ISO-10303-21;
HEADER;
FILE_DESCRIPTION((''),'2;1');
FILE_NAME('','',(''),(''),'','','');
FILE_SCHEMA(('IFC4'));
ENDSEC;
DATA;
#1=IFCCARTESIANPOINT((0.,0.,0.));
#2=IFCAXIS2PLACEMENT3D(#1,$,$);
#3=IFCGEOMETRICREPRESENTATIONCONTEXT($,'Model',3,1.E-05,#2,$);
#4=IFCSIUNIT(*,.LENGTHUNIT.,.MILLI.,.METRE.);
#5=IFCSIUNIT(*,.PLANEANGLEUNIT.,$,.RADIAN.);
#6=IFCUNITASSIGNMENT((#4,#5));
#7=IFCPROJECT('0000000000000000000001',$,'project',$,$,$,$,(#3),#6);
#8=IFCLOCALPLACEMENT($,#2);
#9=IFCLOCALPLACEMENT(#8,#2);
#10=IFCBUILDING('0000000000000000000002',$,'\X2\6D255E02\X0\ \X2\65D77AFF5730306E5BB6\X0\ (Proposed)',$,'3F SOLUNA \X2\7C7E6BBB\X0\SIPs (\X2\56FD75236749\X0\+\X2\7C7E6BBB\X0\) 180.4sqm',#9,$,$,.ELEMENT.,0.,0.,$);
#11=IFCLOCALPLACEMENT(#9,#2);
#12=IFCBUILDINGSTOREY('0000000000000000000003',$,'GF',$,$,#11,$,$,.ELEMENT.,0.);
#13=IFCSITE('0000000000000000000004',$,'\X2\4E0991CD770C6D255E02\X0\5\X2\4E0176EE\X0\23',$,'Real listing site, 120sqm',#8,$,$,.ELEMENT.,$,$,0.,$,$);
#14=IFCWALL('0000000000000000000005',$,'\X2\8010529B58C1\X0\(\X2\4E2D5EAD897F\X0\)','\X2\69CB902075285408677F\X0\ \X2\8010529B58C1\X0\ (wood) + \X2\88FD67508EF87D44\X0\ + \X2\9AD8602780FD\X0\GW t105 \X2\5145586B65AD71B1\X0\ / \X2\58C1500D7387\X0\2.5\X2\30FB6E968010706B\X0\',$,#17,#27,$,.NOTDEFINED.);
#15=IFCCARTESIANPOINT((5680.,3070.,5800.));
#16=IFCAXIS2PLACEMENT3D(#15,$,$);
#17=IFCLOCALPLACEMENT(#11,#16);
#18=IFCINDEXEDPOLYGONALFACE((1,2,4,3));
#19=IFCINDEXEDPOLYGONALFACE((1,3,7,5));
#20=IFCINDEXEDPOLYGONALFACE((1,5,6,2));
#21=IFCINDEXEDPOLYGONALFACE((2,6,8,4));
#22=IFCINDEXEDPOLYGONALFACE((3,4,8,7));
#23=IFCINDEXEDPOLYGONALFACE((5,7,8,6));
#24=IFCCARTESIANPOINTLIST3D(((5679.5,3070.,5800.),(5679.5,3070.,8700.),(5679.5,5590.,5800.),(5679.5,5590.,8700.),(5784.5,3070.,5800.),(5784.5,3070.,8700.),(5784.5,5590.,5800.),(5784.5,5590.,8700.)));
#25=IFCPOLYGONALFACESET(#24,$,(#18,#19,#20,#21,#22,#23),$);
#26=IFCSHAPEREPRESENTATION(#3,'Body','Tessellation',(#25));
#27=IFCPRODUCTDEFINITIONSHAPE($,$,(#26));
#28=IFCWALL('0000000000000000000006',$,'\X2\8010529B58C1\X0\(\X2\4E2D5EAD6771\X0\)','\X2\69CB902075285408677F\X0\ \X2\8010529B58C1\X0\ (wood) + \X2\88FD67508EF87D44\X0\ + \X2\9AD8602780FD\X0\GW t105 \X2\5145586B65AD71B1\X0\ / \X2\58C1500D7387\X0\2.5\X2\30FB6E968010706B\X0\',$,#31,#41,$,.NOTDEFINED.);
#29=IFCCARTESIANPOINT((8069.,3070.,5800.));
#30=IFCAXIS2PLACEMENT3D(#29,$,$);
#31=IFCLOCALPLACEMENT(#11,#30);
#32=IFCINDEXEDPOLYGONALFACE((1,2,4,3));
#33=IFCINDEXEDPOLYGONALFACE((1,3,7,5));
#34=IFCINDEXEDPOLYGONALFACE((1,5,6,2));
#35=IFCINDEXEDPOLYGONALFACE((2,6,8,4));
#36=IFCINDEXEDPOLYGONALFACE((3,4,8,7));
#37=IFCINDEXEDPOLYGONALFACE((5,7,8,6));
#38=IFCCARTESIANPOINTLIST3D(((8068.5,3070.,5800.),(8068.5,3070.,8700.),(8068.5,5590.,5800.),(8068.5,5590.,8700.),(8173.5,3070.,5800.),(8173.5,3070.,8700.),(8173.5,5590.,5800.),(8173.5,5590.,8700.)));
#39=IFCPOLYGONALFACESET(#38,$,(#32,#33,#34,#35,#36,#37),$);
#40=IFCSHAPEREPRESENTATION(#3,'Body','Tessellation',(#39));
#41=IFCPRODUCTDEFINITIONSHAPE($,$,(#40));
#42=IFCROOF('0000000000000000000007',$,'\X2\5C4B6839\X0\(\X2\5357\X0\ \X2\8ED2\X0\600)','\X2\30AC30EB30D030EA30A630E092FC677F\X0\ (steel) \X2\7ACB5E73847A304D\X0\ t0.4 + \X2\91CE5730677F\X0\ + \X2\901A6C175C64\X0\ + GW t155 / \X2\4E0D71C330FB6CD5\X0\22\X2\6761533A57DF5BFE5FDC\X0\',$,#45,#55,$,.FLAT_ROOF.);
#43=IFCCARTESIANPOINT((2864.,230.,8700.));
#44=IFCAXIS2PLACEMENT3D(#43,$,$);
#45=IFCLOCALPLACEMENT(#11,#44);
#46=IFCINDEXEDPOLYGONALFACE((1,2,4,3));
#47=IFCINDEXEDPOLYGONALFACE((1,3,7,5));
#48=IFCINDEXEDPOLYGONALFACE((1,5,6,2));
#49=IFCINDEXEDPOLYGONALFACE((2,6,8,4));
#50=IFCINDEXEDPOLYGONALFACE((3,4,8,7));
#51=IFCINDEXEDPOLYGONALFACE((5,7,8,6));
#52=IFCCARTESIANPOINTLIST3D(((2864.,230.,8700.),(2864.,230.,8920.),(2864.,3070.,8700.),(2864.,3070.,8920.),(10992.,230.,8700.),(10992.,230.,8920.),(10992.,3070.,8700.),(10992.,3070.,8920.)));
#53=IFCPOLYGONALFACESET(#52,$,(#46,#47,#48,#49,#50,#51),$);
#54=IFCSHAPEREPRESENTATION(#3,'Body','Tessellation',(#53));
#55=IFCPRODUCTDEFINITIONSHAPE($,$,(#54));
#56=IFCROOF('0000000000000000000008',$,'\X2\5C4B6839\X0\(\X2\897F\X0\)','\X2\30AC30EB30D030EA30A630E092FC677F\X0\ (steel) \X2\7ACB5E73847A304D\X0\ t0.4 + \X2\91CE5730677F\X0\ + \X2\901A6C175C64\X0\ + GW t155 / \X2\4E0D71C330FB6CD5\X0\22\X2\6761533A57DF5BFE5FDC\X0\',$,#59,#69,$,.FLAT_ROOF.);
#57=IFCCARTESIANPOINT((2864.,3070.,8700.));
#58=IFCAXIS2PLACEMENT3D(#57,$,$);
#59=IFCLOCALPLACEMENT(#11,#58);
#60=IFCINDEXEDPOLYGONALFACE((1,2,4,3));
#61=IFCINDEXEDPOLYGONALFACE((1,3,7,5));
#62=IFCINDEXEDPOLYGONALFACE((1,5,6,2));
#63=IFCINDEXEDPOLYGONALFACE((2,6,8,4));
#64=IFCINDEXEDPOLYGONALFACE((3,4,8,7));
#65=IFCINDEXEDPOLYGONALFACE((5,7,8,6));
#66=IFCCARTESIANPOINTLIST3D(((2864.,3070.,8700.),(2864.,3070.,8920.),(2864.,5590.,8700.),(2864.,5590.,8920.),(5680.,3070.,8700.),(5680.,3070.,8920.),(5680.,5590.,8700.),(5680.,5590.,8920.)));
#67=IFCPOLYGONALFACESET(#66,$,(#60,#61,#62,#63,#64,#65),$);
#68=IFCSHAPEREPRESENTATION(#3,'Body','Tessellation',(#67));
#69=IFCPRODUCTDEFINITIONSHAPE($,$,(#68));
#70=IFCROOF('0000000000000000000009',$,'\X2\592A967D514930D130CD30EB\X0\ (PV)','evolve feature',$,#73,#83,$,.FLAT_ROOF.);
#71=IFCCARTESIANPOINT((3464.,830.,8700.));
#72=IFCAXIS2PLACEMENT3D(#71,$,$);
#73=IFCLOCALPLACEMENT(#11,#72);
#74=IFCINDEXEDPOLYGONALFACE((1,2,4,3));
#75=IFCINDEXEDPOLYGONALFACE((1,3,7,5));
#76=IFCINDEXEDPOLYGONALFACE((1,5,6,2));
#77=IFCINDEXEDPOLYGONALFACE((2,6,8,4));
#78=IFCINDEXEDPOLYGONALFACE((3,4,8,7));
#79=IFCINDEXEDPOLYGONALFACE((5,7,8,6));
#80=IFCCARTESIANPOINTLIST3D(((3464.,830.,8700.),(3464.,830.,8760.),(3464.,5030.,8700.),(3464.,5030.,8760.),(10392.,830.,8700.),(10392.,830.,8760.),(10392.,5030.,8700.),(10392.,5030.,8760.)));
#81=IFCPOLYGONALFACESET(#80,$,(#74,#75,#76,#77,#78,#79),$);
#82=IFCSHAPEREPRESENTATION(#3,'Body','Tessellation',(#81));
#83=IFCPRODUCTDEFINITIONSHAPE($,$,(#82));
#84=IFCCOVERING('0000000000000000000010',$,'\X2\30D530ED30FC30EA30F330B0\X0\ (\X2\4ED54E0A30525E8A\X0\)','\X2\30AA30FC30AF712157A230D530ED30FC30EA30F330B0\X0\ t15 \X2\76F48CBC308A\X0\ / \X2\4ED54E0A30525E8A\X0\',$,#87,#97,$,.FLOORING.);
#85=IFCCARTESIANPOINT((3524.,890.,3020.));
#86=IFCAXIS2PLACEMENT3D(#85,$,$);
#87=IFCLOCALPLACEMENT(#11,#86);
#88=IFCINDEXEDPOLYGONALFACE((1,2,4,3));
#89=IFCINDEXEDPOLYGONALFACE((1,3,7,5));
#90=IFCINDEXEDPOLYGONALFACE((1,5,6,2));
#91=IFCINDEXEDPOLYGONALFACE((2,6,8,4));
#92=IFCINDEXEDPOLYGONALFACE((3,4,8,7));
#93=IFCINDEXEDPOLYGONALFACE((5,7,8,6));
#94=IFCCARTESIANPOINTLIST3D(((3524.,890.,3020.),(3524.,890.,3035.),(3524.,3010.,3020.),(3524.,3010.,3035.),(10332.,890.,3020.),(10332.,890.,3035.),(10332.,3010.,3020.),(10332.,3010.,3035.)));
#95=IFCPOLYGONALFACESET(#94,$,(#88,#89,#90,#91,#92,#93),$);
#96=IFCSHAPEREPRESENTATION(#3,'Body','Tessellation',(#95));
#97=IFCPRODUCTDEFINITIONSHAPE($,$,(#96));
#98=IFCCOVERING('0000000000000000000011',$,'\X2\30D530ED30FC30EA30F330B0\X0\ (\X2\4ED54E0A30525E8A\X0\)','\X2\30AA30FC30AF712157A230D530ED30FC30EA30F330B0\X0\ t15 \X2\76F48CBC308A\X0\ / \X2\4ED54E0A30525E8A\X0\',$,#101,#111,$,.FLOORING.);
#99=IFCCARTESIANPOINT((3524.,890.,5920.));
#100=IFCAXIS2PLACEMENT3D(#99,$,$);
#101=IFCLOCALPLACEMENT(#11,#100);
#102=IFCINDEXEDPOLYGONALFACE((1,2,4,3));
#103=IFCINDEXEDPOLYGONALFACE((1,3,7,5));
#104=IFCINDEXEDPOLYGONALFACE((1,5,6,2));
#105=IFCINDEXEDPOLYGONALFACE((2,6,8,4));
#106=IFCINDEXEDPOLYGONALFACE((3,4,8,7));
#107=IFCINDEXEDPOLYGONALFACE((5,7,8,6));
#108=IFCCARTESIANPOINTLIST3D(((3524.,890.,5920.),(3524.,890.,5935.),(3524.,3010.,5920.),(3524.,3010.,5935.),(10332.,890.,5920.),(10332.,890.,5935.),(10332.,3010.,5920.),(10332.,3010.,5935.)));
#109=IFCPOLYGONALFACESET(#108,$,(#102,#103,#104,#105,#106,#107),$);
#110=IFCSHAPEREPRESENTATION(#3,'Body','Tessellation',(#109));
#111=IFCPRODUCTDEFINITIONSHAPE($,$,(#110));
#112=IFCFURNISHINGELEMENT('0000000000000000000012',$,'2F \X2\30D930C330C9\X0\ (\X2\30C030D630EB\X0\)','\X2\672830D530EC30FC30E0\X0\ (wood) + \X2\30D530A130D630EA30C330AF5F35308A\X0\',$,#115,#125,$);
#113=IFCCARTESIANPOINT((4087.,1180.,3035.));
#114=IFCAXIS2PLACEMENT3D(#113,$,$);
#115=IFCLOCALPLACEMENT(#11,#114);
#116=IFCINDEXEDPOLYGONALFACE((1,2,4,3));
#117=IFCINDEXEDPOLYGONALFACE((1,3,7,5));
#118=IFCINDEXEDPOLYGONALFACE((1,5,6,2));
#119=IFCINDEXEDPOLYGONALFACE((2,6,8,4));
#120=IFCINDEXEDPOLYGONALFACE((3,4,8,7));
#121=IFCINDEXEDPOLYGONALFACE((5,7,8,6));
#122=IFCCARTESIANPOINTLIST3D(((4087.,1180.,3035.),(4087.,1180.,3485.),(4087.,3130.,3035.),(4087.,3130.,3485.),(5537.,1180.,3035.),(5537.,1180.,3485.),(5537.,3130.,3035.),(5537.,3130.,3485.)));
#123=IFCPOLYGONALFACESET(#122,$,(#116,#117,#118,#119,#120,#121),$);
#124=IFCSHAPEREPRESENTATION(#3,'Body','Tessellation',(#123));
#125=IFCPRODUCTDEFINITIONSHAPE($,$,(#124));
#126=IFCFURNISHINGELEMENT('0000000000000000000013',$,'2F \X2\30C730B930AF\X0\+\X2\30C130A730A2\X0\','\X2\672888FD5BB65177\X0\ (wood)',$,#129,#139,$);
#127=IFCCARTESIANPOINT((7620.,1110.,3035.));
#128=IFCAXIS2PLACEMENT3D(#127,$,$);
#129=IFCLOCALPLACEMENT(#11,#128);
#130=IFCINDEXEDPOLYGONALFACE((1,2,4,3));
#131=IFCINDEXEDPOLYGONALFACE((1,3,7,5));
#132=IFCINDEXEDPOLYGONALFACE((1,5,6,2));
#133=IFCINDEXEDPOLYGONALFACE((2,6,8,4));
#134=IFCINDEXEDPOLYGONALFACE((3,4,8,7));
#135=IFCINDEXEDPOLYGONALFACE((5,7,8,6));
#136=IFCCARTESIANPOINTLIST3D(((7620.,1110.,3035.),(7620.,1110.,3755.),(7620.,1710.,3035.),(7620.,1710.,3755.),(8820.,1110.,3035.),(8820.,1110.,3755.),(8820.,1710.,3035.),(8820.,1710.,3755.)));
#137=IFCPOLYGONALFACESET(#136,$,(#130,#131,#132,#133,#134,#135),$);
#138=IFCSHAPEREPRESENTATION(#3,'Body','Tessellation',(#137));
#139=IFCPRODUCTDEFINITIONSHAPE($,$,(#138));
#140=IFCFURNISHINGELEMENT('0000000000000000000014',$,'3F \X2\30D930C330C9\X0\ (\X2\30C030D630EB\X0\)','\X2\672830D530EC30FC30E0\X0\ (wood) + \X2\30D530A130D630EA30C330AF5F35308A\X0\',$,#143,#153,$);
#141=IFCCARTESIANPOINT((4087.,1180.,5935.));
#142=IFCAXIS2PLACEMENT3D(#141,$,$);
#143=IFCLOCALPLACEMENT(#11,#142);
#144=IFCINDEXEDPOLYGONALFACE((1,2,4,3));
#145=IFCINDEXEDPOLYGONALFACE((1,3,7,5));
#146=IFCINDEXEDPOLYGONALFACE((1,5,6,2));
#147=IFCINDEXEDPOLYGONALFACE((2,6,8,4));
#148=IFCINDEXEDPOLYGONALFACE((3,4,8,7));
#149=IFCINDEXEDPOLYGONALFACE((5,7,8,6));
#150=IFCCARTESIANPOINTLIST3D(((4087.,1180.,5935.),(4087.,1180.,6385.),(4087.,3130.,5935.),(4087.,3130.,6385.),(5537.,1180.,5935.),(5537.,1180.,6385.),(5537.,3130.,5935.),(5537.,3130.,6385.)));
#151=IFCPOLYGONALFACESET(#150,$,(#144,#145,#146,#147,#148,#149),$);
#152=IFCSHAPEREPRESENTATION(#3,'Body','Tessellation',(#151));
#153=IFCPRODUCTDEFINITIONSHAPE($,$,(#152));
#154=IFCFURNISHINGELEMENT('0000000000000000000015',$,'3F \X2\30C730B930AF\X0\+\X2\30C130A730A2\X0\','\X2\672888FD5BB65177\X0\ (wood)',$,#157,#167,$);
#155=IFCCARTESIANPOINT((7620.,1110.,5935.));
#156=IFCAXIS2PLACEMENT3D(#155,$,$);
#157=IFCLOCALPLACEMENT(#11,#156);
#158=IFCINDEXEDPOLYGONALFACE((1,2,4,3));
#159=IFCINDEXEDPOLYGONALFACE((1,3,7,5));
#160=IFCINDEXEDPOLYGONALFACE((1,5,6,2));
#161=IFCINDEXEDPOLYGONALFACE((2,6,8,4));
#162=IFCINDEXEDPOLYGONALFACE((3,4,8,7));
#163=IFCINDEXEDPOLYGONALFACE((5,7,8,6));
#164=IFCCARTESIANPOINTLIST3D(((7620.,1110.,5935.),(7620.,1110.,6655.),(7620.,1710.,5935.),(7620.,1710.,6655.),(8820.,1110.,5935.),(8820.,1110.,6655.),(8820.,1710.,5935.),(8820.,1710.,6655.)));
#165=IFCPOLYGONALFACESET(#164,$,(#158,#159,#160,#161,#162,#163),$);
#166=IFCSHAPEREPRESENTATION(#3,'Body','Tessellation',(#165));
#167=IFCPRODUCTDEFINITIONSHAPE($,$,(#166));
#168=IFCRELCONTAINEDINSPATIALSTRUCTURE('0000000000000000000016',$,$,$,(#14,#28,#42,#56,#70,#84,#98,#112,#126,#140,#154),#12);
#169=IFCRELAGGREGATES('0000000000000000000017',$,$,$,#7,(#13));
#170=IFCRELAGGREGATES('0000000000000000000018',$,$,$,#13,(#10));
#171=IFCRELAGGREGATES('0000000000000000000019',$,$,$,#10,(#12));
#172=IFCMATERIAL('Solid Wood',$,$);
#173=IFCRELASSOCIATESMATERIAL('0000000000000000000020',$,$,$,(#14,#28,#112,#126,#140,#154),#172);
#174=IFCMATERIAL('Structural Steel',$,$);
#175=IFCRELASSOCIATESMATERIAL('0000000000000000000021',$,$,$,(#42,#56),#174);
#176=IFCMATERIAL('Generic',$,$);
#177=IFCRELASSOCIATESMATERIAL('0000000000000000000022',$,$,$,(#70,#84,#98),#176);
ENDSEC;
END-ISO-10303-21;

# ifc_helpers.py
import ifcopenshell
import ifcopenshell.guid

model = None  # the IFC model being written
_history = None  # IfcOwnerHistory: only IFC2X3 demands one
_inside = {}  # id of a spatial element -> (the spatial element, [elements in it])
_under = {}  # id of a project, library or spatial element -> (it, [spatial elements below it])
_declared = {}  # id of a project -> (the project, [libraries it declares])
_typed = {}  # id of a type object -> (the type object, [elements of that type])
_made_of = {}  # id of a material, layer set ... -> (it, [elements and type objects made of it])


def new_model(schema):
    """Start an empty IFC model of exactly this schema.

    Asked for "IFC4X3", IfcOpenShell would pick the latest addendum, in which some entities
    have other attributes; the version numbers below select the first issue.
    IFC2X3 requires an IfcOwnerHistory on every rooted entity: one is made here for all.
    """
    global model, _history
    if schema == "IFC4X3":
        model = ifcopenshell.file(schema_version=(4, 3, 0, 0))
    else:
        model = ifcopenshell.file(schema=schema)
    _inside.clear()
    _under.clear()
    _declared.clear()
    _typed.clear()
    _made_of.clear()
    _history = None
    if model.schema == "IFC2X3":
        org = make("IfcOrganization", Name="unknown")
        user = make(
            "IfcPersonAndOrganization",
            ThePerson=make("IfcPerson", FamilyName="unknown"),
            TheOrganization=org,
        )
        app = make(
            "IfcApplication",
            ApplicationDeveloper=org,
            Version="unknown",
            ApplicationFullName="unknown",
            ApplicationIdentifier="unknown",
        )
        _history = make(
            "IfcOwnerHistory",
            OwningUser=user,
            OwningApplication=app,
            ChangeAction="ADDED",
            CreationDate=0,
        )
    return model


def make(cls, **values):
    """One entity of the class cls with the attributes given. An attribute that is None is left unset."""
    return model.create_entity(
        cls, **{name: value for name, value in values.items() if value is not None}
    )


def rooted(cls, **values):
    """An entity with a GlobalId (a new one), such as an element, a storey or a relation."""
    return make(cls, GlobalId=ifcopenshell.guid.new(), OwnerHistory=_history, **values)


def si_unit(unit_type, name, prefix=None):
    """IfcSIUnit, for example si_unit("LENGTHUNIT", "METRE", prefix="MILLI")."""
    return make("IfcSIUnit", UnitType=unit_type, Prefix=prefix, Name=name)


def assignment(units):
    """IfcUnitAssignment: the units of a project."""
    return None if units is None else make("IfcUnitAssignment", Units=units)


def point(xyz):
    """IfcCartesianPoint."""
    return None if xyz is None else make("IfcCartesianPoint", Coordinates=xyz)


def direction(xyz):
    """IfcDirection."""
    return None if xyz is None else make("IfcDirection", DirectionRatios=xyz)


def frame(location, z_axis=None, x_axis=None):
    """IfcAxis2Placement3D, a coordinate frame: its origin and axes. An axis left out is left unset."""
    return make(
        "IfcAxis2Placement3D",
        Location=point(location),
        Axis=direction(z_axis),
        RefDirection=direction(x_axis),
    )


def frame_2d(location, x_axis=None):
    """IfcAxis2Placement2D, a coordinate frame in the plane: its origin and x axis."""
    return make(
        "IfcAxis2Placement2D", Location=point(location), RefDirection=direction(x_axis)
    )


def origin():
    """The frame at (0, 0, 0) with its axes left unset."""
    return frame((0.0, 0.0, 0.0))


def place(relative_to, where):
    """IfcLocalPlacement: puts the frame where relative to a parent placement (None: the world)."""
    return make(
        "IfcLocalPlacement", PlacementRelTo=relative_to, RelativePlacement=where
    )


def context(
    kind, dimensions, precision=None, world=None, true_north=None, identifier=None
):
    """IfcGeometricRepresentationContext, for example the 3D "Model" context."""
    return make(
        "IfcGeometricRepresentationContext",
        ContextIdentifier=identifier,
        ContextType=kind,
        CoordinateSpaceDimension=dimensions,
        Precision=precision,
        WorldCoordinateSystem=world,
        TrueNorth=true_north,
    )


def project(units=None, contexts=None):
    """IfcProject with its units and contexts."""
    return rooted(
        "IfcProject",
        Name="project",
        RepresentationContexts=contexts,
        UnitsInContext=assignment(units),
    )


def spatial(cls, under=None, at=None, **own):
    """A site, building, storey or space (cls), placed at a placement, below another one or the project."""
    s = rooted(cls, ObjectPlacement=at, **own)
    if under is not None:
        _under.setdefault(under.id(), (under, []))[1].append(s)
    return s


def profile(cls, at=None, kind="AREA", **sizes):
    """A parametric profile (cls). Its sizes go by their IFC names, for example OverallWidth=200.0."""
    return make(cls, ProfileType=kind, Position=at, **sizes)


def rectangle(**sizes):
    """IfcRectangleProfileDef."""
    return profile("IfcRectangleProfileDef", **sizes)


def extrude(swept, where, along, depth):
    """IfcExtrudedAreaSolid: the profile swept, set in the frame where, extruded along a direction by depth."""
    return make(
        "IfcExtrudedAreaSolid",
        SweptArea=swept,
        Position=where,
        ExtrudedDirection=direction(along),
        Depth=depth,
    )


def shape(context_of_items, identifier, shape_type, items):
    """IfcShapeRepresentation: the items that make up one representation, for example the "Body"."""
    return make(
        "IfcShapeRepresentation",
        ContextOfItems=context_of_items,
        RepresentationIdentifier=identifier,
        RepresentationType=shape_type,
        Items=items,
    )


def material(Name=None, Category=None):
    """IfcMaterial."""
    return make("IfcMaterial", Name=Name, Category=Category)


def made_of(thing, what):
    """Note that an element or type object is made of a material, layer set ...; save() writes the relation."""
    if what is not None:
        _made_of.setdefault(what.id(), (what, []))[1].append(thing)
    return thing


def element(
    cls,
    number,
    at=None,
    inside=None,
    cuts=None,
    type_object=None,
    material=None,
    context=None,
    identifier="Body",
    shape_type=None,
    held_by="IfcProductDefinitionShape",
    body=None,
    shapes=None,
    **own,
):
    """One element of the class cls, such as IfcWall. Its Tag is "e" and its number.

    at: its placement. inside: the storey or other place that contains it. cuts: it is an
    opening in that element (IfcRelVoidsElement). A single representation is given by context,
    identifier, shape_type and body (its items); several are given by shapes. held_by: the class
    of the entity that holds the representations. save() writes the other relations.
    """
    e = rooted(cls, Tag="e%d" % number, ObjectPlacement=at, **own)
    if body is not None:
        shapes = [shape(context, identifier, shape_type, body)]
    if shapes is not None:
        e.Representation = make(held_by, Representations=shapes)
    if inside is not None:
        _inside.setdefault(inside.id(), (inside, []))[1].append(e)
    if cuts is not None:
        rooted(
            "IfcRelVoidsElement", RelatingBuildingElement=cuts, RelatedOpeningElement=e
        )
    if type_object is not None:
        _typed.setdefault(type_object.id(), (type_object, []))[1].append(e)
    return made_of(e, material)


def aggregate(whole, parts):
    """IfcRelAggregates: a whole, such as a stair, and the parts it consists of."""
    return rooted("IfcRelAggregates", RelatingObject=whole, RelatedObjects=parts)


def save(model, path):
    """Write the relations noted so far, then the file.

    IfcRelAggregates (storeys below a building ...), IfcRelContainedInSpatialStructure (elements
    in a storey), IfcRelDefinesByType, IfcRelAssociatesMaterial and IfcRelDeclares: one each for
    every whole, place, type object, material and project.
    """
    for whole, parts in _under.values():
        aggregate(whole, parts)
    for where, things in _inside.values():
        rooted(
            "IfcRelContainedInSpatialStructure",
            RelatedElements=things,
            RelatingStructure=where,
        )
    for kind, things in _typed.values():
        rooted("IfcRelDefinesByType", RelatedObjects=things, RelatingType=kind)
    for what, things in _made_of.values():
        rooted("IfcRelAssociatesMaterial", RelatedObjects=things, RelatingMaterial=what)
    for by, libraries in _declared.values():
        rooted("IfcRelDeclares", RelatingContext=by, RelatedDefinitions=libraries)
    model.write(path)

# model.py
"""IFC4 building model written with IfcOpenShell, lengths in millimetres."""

from ifc_helpers import new_model, si_unit, frame, frame_2d, origin, place, context, project, spatial, rectangle, extrude, material, element, save


model = new_model("IFC4")

# Units and contexts
model_context = context("Model", 3, precision=1e-05, world=origin())
ifc_project = project(units=[si_unit("LENGTHUNIT", "METRE", prefix="MILLI"), si_unit("PLANEANGLEUNIT", "RADIAN")], contexts=[model_context])

# Site, building, storey
site_placement = place(None, origin())
site = spatial("IfcSite", under=ifc_project, at=site_placement, Name="三重県津市5丁目23", ObjectType="Real listing site, 120sqm", CompositionType="ELEMENT", RefElevation=0.0)
building_placement = place(site_placement, origin())
building = spatial("IfcBuilding", under=site, at=building_placement, Name="津市 旗竿地の家 (Proposed)", ObjectType="3F SOLUNA 籾殻SIPs (国産杉+籾殻) 180.4sqm", CompositionType="ELEMENT", ElevationOfRefHeight=0.0, ElevationOfTerrain=0.0)
storey_placement = place(building_placement, origin())
storey = spatial("IfcBuildingStorey", under=building, at=storey_placement, Name="GF", CompositionType="ELEMENT", Elevation=0.0)

# Shared definitions
ifc_material_1 = material(Name="Solid Wood")

# Walls
wall_1_placement = place(storey_placement, frame((5680.0, 3070.0, 5800.0)))
element("IfcWall", 1, at=wall_1_placement, inside=storey, material=ifc_material_1, Name="耐力壁(中庭西)", Description="構造用合板 耐力壁 (wood) + 製材軸組 + 高性能GW t105 充填断熱 / 壁倍率2.5・準耐火", PredefinedType="NOTDEFINED", context=model_context, shape_type="SweptSolid", body=[
    extrude(rectangle(XDim=105.0, YDim=2520.0, at=frame_2d((52.0, 1260.0))), frame((5680.0, 3070.0, 5800.0)), (0.0, 0.0, 1.0), 2900.0),
])
wall_2_placement = place(storey_placement, frame((8069.0, 3070.0, 5800.0)))
element("IfcWall", 2, at=wall_2_placement, inside=storey, material=ifc_material_1, Name="耐力壁(中庭東)", Description="構造用合板 耐力壁 (wood) + 製材軸組 + 高性能GW t105 充填断熱 / 壁倍率2.5・準耐火", PredefinedType="NOTDEFINED", context=model_context, shape_type="SweptSolid", body=[
    extrude(rectangle(XDim=105.0, YDim=2520.0, at=frame_2d((52.0, 1260.0))), frame((8069.0, 3070.0, 5800.0)), (0.0, 0.0, 1.0), 2900.0),
])

# Roofs
ifc_material_2 = material(Name="Structural Steel")
roof_1_placement = place(storey_placement, frame((2864.0, 230.0, 8700.0)))
element("IfcRoof", 3, at=roof_1_placement, inside=storey, material=ifc_material_2, Name="屋根(南 軒600)", Description="ガルバリウム鋼板 (steel) 立平葺き t0.4 + 野地板 + 通気層 + GW t155 / 不燃・法22条区域対応", PredefinedType="FLAT_ROOF", context=model_context, shape_type="SweptSolid", body=[
    extrude(rectangle(XDim=8128.0, YDim=2840.0, at=frame_2d((4064.0, 1420.0))), frame((2864.0, 230.0, 8700.0)), (0.0, 0.0, 1.0), 220.0),
])
roof_2_placement = place(storey_placement, frame((2864.0, 3070.0, 8700.0)))
element("IfcRoof", 4, at=roof_2_placement, inside=storey, material=ifc_material_2, Name="屋根(西)", Description="ガルバリウム鋼板 (steel) 立平葺き t0.4 + 野地板 + 通気層 + GW t155 / 不燃・法22条区域対応", PredefinedType="FLAT_ROOF", context=model_context, shape_type="SweptSolid", body=[
    extrude(rectangle(XDim=2816.0, YDim=2520.0, at=frame_2d((1408.0, 1260.0))), frame((2864.0, 3070.0, 8700.0)), (0.0, 0.0, 1.0), 220.0),
])
ifc_material_3 = material(Name="Generic")
roof_3_placement = place(storey_placement, frame((3464.0, 830.0, 8700.0)))
element("IfcRoof", 5, at=roof_3_placement, inside=storey, material=ifc_material_3, Name="太陽光パネル (PV)", Description="evolve feature", PredefinedType="FLAT_ROOF", context=model_context, shape_type="SweptSolid", body=[
    extrude(rectangle(XDim=6928.0, YDim=4200.0, at=frame_2d((3464.0, 2100.0))), frame((3464.0, 830.0, 8700.0)), (0.0, 0.0, 1.0), 60.0),
])

# Coverings
covering_1_placement = place(storey_placement, frame((3524.0, 890.0, 3020.0)))
element("IfcCovering", 6, at=covering_1_placement, inside=storey, material=ifc_material_3, Name="フローリング (仕上げ床)", Description="オーク無垢フローリング t15 直貼り / 仕上げ床", PredefinedType="FLOORING", context=model_context, shape_type="SweptSolid", body=[
    extrude(rectangle(XDim=6808.0, YDim=2120.0, at=frame_2d((3404.0, 1060.0))), frame((3524.0, 890.0, 3020.0)), (0.0, 0.0, 1.0), 15.0),
])
covering_2_placement = place(storey_placement, frame((3524.0, 890.0, 5920.0)))
element("IfcCovering", 7, at=covering_2_placement, inside=storey, material=ifc_material_3, Name="フローリング (仕上げ床)", Description="オーク無垢フローリング t15 直貼り / 仕上げ床", PredefinedType="FLOORING", context=model_context, shape_type="SweptSolid", body=[
    extrude(rectangle(XDim=6808.0, YDim=2120.0, at=frame_2d((3404.0, 1060.0))), frame((3524.0, 890.0, 5920.0)), (0.0, 0.0, 1.0), 15.0),
])

# Furnishing elements
furnishing_1_placement = place(storey_placement, frame((4087.0, 1180.0, 3035.0)))
element("IfcFurnishingElement", 8, at=furnishing_1_placement, inside=storey, material=ifc_material_1, Name="2F ベッド (ダブル)", Description="木フレーム (wood) + ファブリック張り", context=model_context, shape_type="SweptSolid", body=[
    extrude(rectangle(XDim=1450.0, YDim=1950.0, at=frame_2d((725.0, 975.0))), frame((4087.0, 1180.0, 3035.0)), (0.0, 0.0, 1.0), 450.0),
])
furnishing_2_placement = place(storey_placement, frame((7620.0, 1110.0, 3035.0)))
element("IfcFurnishingElement", 9, at=furnishing_2_placement, inside=storey, material=ifc_material_1, Name="2F デスク+チェア", Description="木製家具 (wood)", context=model_context, shape_type="SweptSolid", body=[
    extrude(rectangle(XDim=1200.0, YDim=600.0, at=frame_2d((600.0, 300.0))), frame((7620.0, 1110.0, 3035.0)), (0.0, 0.0, 1.0), 720.0),
])
furnishing_3_placement = place(storey_placement, frame((4087.0, 1180.0, 5935.0)))
element("IfcFurnishingElement", 10, at=furnishing_3_placement, inside=storey, material=ifc_material_1, Name="3F ベッド (ダブル)", Description="木フレーム (wood) + ファブリック張り", context=model_context, shape_type="SweptSolid", body=[
    extrude(rectangle(XDim=1450.0, YDim=1950.0, at=frame_2d((725.0, 975.0))), frame((4087.0, 1180.0, 5935.0)), (0.0, 0.0, 1.0), 450.0),
])
furnishing_4_placement = place(storey_placement, frame((7620.0, 1110.0, 5935.0)))
element("IfcFurnishingElement", 11, at=furnishing_4_placement, inside=storey, material=ifc_material_1, Name="3F デスク+チェア", Description="木製家具 (wood)", context=model_context, shape_type="SweptSolid", body=[
    extrude(rectangle(XDim=1200.0, YDim=600.0, at=frame_2d((600.0, 300.0))), frame((7620.0, 1110.0, 5935.0)), (0.0, 0.0, 1.0), 720.0),
])

save(model, "model.ifc")
